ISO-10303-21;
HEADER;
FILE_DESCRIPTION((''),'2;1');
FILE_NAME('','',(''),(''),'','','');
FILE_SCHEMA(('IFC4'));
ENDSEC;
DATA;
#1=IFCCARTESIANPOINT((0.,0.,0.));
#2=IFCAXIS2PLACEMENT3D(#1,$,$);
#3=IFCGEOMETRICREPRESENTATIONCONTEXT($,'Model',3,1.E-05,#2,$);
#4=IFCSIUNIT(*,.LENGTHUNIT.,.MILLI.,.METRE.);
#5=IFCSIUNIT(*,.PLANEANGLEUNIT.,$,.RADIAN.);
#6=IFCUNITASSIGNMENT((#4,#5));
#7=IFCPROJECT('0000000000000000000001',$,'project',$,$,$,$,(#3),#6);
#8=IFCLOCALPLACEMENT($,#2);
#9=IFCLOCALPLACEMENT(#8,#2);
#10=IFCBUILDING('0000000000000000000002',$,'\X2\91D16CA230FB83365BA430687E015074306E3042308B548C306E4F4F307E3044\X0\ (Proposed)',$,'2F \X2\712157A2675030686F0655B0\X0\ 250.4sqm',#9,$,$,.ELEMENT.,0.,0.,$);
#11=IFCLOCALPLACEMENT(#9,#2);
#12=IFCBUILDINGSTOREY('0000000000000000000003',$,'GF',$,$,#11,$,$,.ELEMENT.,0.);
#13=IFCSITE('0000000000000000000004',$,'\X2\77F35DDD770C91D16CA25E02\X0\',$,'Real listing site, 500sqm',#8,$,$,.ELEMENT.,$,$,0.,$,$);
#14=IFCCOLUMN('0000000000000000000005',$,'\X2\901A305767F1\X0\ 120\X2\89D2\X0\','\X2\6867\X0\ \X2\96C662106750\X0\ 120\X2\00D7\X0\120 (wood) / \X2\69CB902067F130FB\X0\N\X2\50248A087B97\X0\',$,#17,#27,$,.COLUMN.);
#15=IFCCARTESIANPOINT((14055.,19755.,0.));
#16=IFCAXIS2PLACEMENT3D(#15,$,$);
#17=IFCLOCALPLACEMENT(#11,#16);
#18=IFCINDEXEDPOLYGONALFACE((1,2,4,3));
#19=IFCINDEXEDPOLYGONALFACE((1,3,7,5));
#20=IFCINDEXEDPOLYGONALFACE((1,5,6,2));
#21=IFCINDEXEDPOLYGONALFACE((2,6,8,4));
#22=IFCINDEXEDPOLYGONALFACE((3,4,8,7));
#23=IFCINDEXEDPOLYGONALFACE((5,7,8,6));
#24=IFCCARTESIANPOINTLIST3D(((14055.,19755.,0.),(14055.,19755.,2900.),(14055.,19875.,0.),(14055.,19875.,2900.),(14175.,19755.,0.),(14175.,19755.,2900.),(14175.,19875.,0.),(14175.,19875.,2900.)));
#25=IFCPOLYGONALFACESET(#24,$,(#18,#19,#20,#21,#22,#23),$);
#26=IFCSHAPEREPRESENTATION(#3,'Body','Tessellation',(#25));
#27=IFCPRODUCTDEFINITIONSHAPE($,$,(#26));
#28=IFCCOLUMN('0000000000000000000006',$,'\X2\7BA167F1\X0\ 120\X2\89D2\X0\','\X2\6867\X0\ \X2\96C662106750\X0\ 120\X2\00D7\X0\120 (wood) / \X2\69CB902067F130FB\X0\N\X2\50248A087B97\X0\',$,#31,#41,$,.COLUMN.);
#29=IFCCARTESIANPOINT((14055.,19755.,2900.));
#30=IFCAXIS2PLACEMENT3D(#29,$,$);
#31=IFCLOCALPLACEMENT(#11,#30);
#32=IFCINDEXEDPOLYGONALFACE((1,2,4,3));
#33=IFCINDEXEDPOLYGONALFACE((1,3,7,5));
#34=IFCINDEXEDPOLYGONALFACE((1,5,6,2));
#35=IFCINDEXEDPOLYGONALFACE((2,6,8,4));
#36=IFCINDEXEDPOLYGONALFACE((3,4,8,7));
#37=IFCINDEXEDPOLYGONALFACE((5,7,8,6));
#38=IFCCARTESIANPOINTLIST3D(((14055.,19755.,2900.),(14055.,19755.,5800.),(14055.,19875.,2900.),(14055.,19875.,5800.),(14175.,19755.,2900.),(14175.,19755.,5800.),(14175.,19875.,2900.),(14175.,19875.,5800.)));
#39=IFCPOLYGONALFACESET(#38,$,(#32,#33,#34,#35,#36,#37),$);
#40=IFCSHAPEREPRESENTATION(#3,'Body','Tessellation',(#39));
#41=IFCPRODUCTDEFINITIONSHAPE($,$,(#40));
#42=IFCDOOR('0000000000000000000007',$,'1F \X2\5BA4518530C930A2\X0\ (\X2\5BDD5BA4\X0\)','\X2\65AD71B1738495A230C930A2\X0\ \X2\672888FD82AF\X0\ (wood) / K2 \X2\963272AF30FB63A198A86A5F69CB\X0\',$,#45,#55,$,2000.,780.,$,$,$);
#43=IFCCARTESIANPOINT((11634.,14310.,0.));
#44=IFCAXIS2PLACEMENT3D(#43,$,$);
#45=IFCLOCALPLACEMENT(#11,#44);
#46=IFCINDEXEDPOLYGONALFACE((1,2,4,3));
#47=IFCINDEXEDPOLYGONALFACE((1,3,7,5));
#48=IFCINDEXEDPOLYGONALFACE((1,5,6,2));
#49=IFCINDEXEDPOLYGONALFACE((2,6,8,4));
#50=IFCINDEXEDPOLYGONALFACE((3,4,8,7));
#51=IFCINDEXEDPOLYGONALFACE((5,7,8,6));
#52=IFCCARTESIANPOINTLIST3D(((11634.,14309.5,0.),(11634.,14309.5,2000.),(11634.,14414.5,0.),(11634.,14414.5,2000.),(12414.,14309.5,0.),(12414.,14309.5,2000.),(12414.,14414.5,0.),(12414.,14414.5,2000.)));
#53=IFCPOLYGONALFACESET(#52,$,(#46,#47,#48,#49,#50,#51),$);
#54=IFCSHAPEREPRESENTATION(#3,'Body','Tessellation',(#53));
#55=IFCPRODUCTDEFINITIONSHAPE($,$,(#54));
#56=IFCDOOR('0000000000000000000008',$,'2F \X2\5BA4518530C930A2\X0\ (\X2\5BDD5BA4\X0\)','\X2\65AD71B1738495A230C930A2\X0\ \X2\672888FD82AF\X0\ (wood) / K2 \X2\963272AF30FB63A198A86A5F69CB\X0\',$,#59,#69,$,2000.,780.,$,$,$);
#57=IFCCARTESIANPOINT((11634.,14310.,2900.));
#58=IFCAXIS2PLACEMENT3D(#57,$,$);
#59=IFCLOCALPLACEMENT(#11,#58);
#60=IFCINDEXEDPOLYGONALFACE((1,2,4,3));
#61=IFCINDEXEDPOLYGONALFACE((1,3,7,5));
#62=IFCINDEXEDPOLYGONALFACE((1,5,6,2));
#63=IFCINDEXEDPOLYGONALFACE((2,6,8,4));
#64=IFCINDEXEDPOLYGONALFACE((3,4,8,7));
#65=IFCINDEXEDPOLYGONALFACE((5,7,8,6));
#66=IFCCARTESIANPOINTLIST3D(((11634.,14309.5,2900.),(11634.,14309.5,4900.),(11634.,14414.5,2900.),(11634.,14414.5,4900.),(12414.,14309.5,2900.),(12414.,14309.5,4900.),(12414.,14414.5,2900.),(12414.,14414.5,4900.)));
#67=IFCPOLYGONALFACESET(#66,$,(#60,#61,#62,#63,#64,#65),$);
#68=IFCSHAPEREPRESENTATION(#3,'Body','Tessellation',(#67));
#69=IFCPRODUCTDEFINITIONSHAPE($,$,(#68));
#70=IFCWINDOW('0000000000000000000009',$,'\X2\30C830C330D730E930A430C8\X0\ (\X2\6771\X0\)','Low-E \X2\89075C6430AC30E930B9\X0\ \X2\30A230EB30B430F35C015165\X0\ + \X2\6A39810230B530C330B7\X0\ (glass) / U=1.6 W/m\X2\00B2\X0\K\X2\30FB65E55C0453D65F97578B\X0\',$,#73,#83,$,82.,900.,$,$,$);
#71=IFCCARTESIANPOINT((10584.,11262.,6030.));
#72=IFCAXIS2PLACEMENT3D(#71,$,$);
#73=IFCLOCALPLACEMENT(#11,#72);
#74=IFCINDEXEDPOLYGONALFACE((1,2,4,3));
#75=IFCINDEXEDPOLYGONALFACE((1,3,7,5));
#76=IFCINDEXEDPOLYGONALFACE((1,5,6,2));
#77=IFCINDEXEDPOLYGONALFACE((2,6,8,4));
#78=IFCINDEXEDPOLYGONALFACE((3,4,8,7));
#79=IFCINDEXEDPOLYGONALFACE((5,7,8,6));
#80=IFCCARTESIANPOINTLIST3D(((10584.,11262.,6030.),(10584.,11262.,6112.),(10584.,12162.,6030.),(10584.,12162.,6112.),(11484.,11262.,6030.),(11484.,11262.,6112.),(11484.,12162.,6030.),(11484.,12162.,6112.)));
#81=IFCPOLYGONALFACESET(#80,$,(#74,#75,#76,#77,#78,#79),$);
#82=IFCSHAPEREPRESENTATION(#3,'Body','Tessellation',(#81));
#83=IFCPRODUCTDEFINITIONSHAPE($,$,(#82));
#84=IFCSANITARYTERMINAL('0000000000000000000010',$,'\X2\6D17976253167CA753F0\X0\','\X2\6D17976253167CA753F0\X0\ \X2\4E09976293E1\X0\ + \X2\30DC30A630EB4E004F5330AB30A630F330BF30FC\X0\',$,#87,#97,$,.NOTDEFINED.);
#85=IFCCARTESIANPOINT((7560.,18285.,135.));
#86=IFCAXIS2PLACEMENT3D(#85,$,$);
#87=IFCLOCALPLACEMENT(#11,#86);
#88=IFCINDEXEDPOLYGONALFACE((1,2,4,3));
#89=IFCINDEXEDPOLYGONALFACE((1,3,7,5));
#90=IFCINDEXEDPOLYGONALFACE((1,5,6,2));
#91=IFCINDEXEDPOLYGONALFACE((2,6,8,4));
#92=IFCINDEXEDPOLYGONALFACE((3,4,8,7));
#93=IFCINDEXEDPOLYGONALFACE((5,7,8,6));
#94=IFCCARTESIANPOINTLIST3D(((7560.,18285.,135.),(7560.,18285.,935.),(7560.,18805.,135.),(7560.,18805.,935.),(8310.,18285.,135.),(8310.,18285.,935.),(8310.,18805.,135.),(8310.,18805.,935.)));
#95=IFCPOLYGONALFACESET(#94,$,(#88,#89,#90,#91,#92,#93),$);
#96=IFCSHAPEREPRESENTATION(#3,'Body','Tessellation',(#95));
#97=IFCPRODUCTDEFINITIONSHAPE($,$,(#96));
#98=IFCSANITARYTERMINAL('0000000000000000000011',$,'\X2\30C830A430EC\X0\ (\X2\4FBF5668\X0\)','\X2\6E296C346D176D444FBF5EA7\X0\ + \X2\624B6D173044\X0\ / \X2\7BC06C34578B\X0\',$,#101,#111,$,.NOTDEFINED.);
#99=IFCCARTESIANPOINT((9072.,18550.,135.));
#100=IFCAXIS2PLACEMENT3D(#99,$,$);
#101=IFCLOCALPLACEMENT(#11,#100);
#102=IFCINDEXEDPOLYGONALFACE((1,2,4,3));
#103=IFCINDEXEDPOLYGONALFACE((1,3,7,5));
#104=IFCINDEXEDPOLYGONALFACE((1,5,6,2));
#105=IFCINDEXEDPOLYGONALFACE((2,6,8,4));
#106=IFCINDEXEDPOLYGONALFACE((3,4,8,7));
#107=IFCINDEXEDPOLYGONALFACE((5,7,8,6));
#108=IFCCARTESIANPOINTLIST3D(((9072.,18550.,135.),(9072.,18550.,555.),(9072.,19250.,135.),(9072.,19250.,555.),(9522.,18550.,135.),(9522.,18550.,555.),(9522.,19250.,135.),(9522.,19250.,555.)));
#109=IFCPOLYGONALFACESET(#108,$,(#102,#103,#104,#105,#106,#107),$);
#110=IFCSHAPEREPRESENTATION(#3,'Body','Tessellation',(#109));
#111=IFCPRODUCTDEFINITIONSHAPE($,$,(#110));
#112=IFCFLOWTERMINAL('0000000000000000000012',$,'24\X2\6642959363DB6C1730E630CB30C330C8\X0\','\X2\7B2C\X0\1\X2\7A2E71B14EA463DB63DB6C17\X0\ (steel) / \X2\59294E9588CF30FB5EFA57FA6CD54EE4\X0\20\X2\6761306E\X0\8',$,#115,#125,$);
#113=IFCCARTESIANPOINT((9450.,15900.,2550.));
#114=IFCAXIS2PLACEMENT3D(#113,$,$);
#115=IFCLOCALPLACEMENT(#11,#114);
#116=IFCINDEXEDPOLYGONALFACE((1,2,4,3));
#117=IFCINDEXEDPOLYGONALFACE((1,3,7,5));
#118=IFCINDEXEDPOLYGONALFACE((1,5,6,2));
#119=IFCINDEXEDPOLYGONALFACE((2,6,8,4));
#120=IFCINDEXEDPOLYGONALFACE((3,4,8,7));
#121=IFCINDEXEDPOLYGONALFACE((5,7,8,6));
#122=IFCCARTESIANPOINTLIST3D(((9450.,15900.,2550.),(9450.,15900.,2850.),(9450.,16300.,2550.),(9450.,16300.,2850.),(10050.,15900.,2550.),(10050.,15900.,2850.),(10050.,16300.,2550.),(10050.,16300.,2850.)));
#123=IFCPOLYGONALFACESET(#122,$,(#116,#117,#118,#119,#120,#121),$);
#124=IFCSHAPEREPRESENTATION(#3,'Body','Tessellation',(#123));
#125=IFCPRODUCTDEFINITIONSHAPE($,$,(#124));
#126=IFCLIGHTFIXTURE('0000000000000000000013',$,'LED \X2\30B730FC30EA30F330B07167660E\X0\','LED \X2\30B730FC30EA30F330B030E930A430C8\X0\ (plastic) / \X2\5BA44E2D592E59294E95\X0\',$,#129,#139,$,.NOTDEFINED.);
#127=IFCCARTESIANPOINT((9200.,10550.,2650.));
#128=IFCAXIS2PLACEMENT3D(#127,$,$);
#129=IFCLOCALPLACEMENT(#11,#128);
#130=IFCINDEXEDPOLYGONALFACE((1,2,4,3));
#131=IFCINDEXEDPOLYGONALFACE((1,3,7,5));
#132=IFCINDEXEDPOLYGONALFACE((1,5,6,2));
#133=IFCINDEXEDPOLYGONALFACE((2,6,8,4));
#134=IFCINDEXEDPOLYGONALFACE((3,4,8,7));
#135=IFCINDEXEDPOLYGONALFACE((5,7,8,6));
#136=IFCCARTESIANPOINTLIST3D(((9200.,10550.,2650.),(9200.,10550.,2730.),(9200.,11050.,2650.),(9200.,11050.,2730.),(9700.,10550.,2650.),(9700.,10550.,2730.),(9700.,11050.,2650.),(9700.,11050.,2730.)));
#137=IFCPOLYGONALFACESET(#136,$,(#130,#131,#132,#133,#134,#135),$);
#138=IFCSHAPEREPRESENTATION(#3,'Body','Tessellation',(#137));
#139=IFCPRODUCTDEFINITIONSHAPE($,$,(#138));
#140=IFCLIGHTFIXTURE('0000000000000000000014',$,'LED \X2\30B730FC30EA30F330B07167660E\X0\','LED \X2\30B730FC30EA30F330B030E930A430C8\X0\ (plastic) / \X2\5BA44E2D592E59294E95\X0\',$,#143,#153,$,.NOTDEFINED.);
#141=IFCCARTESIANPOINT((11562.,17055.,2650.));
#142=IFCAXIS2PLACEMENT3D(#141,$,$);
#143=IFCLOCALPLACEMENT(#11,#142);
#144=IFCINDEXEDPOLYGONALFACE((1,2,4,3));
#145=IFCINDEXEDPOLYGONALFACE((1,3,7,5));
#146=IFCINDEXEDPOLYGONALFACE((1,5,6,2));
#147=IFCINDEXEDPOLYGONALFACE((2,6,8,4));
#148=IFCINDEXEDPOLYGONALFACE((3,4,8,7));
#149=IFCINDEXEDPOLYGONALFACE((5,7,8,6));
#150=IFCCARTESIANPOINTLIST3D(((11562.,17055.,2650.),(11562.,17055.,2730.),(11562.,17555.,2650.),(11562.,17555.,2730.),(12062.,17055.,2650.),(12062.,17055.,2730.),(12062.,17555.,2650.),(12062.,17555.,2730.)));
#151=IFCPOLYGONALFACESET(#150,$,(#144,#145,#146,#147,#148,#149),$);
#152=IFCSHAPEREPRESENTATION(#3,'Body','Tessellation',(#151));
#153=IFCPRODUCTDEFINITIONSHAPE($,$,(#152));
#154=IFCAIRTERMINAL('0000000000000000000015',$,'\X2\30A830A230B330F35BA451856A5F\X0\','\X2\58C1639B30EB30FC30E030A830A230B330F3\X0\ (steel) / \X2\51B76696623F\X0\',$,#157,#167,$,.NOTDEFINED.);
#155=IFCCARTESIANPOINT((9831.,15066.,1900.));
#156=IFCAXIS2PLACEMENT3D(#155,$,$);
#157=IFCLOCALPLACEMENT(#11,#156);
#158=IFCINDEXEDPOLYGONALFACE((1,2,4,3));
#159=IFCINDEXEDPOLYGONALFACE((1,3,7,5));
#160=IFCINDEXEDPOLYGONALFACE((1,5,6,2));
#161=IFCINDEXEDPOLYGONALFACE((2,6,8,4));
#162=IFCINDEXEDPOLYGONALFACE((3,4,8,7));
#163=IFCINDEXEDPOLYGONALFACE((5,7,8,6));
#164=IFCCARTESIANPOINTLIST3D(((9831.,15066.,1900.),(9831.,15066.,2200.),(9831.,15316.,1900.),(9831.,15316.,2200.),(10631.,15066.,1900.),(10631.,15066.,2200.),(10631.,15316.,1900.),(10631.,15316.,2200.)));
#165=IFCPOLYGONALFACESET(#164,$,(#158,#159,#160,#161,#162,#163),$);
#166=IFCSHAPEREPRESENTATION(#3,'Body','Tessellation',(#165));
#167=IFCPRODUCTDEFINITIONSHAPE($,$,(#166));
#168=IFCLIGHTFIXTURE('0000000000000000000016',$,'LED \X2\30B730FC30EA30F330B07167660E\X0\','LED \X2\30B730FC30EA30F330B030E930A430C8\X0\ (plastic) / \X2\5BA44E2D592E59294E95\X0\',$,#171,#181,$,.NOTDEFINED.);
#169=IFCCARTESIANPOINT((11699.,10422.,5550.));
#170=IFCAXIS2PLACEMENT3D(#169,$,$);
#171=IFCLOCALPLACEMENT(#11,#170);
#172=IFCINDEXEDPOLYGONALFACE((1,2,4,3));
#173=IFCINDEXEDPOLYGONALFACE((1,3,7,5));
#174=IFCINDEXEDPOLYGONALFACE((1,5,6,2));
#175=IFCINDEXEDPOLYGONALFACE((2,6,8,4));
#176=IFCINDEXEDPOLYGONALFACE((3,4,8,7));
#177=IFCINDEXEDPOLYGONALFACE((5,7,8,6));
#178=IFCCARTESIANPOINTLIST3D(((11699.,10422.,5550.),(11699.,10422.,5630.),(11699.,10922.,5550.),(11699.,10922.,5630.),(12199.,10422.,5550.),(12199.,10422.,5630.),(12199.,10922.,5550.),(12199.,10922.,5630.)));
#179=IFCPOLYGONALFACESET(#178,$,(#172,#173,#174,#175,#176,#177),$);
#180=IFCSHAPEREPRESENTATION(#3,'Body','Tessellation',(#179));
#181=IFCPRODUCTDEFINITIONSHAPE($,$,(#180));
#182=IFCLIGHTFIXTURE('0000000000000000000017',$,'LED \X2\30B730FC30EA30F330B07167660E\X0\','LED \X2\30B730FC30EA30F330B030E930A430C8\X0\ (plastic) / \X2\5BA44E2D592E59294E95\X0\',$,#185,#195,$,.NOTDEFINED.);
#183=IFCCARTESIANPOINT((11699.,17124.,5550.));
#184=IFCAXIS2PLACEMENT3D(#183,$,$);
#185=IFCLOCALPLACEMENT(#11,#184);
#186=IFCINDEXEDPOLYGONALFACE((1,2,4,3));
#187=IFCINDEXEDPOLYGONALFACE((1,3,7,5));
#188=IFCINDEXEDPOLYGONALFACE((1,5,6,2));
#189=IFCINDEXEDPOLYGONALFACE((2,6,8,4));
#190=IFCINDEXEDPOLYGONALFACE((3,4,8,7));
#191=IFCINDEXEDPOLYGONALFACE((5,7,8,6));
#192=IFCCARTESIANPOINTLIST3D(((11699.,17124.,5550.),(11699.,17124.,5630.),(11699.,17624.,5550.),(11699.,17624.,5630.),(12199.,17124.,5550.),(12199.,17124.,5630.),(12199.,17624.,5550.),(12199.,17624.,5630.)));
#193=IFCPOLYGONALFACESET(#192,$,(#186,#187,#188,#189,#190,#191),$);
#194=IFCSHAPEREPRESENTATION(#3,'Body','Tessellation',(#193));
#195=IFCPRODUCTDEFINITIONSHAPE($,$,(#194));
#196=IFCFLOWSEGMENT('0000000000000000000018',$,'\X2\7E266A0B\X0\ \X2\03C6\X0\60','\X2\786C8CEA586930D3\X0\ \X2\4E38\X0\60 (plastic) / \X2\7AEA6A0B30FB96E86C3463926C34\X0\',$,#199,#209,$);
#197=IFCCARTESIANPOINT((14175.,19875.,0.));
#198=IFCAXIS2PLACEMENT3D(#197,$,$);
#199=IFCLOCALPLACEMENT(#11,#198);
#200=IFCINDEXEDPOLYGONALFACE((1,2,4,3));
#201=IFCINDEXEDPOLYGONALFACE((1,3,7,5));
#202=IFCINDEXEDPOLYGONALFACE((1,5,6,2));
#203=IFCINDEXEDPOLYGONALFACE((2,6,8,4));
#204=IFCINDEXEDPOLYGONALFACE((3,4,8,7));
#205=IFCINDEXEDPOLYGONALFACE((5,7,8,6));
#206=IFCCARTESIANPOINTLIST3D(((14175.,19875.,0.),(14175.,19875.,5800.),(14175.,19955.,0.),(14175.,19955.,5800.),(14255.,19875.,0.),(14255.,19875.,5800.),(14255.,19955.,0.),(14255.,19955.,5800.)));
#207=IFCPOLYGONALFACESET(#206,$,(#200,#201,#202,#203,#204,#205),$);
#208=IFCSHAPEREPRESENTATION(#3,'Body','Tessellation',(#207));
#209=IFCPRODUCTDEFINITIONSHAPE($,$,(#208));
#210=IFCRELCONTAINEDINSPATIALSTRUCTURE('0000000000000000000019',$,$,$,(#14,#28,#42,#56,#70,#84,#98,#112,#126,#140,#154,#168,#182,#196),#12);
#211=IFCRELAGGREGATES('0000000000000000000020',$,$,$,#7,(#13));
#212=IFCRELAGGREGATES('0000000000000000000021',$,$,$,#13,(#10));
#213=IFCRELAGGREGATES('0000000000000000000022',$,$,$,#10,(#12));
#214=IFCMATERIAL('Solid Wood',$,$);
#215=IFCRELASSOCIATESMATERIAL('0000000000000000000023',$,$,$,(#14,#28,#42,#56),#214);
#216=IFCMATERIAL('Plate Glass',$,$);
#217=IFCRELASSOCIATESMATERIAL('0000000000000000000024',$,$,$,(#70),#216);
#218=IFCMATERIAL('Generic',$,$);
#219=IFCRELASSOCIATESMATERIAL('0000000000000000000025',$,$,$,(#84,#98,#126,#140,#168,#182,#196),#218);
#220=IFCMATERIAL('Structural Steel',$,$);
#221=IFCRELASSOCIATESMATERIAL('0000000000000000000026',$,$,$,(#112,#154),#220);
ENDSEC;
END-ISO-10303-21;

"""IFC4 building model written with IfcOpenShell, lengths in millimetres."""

from ifc_helpers import new_model, si_unit, frame, frame_2d, origin, place, context, project, spatial, rectangle, extrude, material, element, save


model = new_model("IFC4")

# Units and contexts
model_context = context("Model", 3, precision=1e-05, world=origin())
ifc_project = project(units=[si_unit("LENGTHUNIT", "METRE", prefix="MILLI"), si_unit("PLANEANGLEUNIT", "RADIAN")], contexts=[model_context])

# Site, building, storey
site_placement = place(None, origin())
site = spatial("IfcSite", under=ifc_project, at=site_placement, Name="石川県金沢市", ObjectType="Real listing site, 500sqm", CompositionType="ELEMENT", RefElevation=0.0)
building_placement = place(site_placement, origin())
building = spatial("IfcBuilding", under=site, at=building_placement, Name="金沢・茶室と縁側のある和の住まい (Proposed)", ObjectType="2F 無垢材と漆喰 250.4sqm", CompositionType="ELEMENT", ElevationOfRefHeight=0.0, ElevationOfTerrain=0.0)
storey_placement = place(building_placement, origin())
storey = spatial("IfcBuildingStorey", under=building, at=storey_placement, Name="GF", CompositionType="ELEMENT", Elevation=0.0)

# Columns
ifc_material_1 = material(Name="Solid Wood")
column_1_placement = place(storey_placement, frame((14055.0, 19755.0, 0.0)))
element("IfcColumn", 1, at=column_1_placement, inside=storey, material=ifc_material_1, Name="通し柱 120角", Description="桧 集成材 120×120 (wood) / 構造柱・N値計算", PredefinedType="COLUMN", context=model_context, shape_type="SweptSolid", body=[
    extrude(rectangle(XDim=120.0, YDim=120.0, at=frame_2d((60.0, 60.0))), frame((14055.0, 19755.0, 0.0)), (0.0, 0.0, 1.0), 2900.0),
])
column_2_placement = place(storey_placement, frame((14055.0, 19755.0, 2900.0)))
element("IfcColumn", 2, at=column_2_placement, inside=storey, material=ifc_material_1, Name="管柱 120角", Description="桧 集成材 120×120 (wood) / 構造柱・N値計算", PredefinedType="COLUMN", context=model_context, shape_type="SweptSolid", body=[
    extrude(rectangle(XDim=120.0, YDim=120.0, at=frame_2d((60.0, 60.0))), frame((14055.0, 19755.0, 2900.0)), (0.0, 0.0, 1.0), 2900.0),
])

# Door
door_1_placement = place(storey_placement, frame((11634.0, 14310.0, 0.0)))
element("IfcDoor", 3, at=door_1_placement, inside=storey, material=ifc_material_1, Name="1F 室内ドア (寝室)", Description="断熱玄関ドア 木製芯 (wood) / K2 防犯・採風機構", OverallHeight=2000.0, OverallWidth=780.0, context=model_context, shape_type="SweptSolid", body=[
    extrude(rectangle(XDim=780.0, YDim=105.0, at=frame_2d((390.0, 52.0))), frame((11634.0, 14310.0, 0.0)), (0.0, 0.0, 1.0), 2000.0),
])

# Door
door_2_placement = place(storey_placement, frame((11634.0, 14310.0, 2900.0)))
element("IfcDoor", 4, at=door_2_placement, inside=storey, material=ifc_material_1, Name="2F 室内ドア (寝室)", Description="断熱玄関ドア 木製芯 (wood) / K2 防犯・採風機構", OverallHeight=2000.0, OverallWidth=780.0, context=model_context, shape_type="SweptSolid", body=[
    extrude(rectangle(XDim=780.0, YDim=105.0, at=frame_2d((390.0, 52.0))), frame((11634.0, 14310.0, 2900.0)), (0.0, 0.0, 1.0), 2000.0),
])

# Window
ifc_material_2 = material(Name="Plate Glass")
window_placement = place(storey_placement, frame((10584.0, 11262.0, 6030.0)))
element("IfcWindow", 5, at=window_placement, inside=storey, material=ifc_material_2, Name="トップライト (東)", Description="Low-E 複層ガラス アルゴン封入 + 樹脂サッシ (glass) / U=1.6 W/m²K・日射取得型", OverallHeight=82.0, OverallWidth=900.0, context=model_context, shape_type="SweptSolid", body=[
    extrude(rectangle(XDim=900.0, YDim=900.0, at=frame_2d((450.0, 450.0))), frame((10584.0, 11262.0, 6030.0)), (0.0, 0.0, 1.0), 82.0),
])

# Sanitary terminals
ifc_material_3 = material(Name="Generic")
sanitary_terminal_1_placement = place(storey_placement, frame((7560.0, 18285.0, 135.0)))
element("IfcSanitaryTerminal", 6, at=sanitary_terminal_1_placement, inside=storey, material=ifc_material_3, Name="洗面化粧台", Description="洗面化粧台 三面鏡 + ボウル一体カウンター", PredefinedType="NOTDEFINED", context=model_context, shape_type="SweptSolid", body=[
    extrude(rectangle(XDim=750.0, YDim=520.0, at=frame_2d((375.0, 260.0))), frame((7560.0, 18285.0, 135.0)), (0.0, 0.0, 1.0), 800.0),
])
sanitary_terminal_2_placement = place(storey_placement, frame((9072.0, 18550.0, 135.0)))
element("IfcSanitaryTerminal", 7, at=sanitary_terminal_2_placement, inside=storey, material=ifc_material_3, Name="トイレ (便器)", Description="温水洗浄便座 + 手洗い / 節水型", PredefinedType="NOTDEFINED", context=model_context, shape_type="SweptSolid", body=[
    extrude(rectangle(XDim=450.0, YDim=700.0, at=frame_2d((225.0, 350.0))), frame((9072.0, 18550.0, 135.0)), (0.0, 0.0, 1.0), 420.0),
])

# Flow terminal
ifc_material_4 = material(Name="Structural Steel")
flow_terminal_placement = place(storey_placement, frame((9450.0, 15900.0, 2550.0)))
element("IfcFlowTerminal", 8, at=flow_terminal_placement, inside=storey, material=ifc_material_4, Name="24時間換気ユニット", Description="第1種熱交換換気 (steel) / 天井裏・建基法令20条の8", context=model_context, shape_type="SweptSolid", body=[
    extrude(rectangle(XDim=600.0, YDim=400.0, at=frame_2d((300.0, 200.0))), frame((9450.0, 15900.0, 2550.0)), (0.0, 0.0, 1.0), 300.0),
])

# Light fixtures
light_fixture_1_placement = place(storey_placement, frame((9200.0, 10550.0, 2650.0)))
element("IfcLightFixture", 9, at=light_fixture_1_placement, inside=storey, material=ifc_material_3, Name="LED シーリング照明", Description="LED シーリングライト (plastic) / 室中央天井", PredefinedType="NOTDEFINED", context=model_context, shape_type="SweptSolid", body=[
    extrude(rectangle(XDim=500.0, YDim=500.0, at=frame_2d((250.0, 250.0))), frame((9200.0, 10550.0, 2650.0)), (0.0, 0.0, 1.0), 80.0),
])
light_fixture_2_placement = place(storey_placement, frame((11562.0, 17055.0, 2650.0)))
element("IfcLightFixture", 10, at=light_fixture_2_placement, inside=storey, material=ifc_material_3, Name="LED シーリング照明", Description="LED シーリングライト (plastic) / 室中央天井", PredefinedType="NOTDEFINED", context=model_context, shape_type="SweptSolid", body=[
    extrude(rectangle(XDim=500.0, YDim=500.0, at=frame_2d((250.0, 250.0))), frame((11562.0, 17055.0, 2650.0)), (0.0, 0.0, 1.0), 80.0),
])

# Air terminal
air_terminal_placement = place(storey_placement, frame((9831.0, 15066.0, 1900.0)))
element("IfcAirTerminal", 11, at=air_terminal_placement, inside=storey, material=ifc_material_4, Name="エアコン室内機", Description="壁掛ルームエアコン (steel) / 冷暖房", PredefinedType="NOTDEFINED", context=model_context, shape_type="SweptSolid", body=[
    extrude(rectangle(XDim=800.0, YDim=250.0, at=frame_2d((400.0, 125.0))), frame((9831.0, 15066.0, 1900.0)), (0.0, 0.0, 1.0), 300.0),
])

# Light fixtures
light_fixture_3_placement = place(storey_placement, frame((11699.0, 10422.0, 5550.0)))
element("IfcLightFixture", 12, at=light_fixture_3_placement, inside=storey, material=ifc_material_3, Name="LED シーリング照明", Description="LED シーリングライト (plastic) / 室中央天井", PredefinedType="NOTDEFINED", context=model_context, shape_type="SweptSolid", body=[
    extrude(rectangle(XDim=500.0, YDim=500.0, at=frame_2d((250.0, 250.0))), frame((11699.0, 10422.0, 5550.0)), (0.0, 0.0, 1.0), 80.0),
])
light_fixture_4_placement = place(storey_placement, frame((11699.0, 17124.0, 5550.0)))
element("IfcLightFixture", 13, at=light_fixture_4_placement, inside=storey, material=ifc_material_3, Name="LED シーリング照明", Description="LED シーリングライト (plastic) / 室中央天井", PredefinedType="NOTDEFINED", context=model_context, shape_type="SweptSolid", body=[
    extrude(rectangle(XDim=500.0, YDim=500.0, at=frame_2d((250.0, 250.0))), frame((11699.0, 17124.0, 5550.0)), (0.0, 0.0, 1.0), 80.0),
])

# Flow segment
flow_segment_placement = place(storey_placement, frame((14175.0, 19875.0, 0.0)))
element("IfcFlowSegment", 14, at=flow_segment_placement, inside=storey, material=ifc_material_3, Name="縦樋 φ60", Description="硬質塩ビ 丸60 (plastic) / 竪樋・雨水排水", context=model_context, shape_type="SweptSolid", body=[
    extrude(rectangle(XDim=80.0, YDim=80.0, at=frame_2d((40.0, 40.0))), frame((14175.0, 19875.0, 0.0)), (0.0, 0.0, 1.0), 5800.0),
])

save(model, "model.ifc")
